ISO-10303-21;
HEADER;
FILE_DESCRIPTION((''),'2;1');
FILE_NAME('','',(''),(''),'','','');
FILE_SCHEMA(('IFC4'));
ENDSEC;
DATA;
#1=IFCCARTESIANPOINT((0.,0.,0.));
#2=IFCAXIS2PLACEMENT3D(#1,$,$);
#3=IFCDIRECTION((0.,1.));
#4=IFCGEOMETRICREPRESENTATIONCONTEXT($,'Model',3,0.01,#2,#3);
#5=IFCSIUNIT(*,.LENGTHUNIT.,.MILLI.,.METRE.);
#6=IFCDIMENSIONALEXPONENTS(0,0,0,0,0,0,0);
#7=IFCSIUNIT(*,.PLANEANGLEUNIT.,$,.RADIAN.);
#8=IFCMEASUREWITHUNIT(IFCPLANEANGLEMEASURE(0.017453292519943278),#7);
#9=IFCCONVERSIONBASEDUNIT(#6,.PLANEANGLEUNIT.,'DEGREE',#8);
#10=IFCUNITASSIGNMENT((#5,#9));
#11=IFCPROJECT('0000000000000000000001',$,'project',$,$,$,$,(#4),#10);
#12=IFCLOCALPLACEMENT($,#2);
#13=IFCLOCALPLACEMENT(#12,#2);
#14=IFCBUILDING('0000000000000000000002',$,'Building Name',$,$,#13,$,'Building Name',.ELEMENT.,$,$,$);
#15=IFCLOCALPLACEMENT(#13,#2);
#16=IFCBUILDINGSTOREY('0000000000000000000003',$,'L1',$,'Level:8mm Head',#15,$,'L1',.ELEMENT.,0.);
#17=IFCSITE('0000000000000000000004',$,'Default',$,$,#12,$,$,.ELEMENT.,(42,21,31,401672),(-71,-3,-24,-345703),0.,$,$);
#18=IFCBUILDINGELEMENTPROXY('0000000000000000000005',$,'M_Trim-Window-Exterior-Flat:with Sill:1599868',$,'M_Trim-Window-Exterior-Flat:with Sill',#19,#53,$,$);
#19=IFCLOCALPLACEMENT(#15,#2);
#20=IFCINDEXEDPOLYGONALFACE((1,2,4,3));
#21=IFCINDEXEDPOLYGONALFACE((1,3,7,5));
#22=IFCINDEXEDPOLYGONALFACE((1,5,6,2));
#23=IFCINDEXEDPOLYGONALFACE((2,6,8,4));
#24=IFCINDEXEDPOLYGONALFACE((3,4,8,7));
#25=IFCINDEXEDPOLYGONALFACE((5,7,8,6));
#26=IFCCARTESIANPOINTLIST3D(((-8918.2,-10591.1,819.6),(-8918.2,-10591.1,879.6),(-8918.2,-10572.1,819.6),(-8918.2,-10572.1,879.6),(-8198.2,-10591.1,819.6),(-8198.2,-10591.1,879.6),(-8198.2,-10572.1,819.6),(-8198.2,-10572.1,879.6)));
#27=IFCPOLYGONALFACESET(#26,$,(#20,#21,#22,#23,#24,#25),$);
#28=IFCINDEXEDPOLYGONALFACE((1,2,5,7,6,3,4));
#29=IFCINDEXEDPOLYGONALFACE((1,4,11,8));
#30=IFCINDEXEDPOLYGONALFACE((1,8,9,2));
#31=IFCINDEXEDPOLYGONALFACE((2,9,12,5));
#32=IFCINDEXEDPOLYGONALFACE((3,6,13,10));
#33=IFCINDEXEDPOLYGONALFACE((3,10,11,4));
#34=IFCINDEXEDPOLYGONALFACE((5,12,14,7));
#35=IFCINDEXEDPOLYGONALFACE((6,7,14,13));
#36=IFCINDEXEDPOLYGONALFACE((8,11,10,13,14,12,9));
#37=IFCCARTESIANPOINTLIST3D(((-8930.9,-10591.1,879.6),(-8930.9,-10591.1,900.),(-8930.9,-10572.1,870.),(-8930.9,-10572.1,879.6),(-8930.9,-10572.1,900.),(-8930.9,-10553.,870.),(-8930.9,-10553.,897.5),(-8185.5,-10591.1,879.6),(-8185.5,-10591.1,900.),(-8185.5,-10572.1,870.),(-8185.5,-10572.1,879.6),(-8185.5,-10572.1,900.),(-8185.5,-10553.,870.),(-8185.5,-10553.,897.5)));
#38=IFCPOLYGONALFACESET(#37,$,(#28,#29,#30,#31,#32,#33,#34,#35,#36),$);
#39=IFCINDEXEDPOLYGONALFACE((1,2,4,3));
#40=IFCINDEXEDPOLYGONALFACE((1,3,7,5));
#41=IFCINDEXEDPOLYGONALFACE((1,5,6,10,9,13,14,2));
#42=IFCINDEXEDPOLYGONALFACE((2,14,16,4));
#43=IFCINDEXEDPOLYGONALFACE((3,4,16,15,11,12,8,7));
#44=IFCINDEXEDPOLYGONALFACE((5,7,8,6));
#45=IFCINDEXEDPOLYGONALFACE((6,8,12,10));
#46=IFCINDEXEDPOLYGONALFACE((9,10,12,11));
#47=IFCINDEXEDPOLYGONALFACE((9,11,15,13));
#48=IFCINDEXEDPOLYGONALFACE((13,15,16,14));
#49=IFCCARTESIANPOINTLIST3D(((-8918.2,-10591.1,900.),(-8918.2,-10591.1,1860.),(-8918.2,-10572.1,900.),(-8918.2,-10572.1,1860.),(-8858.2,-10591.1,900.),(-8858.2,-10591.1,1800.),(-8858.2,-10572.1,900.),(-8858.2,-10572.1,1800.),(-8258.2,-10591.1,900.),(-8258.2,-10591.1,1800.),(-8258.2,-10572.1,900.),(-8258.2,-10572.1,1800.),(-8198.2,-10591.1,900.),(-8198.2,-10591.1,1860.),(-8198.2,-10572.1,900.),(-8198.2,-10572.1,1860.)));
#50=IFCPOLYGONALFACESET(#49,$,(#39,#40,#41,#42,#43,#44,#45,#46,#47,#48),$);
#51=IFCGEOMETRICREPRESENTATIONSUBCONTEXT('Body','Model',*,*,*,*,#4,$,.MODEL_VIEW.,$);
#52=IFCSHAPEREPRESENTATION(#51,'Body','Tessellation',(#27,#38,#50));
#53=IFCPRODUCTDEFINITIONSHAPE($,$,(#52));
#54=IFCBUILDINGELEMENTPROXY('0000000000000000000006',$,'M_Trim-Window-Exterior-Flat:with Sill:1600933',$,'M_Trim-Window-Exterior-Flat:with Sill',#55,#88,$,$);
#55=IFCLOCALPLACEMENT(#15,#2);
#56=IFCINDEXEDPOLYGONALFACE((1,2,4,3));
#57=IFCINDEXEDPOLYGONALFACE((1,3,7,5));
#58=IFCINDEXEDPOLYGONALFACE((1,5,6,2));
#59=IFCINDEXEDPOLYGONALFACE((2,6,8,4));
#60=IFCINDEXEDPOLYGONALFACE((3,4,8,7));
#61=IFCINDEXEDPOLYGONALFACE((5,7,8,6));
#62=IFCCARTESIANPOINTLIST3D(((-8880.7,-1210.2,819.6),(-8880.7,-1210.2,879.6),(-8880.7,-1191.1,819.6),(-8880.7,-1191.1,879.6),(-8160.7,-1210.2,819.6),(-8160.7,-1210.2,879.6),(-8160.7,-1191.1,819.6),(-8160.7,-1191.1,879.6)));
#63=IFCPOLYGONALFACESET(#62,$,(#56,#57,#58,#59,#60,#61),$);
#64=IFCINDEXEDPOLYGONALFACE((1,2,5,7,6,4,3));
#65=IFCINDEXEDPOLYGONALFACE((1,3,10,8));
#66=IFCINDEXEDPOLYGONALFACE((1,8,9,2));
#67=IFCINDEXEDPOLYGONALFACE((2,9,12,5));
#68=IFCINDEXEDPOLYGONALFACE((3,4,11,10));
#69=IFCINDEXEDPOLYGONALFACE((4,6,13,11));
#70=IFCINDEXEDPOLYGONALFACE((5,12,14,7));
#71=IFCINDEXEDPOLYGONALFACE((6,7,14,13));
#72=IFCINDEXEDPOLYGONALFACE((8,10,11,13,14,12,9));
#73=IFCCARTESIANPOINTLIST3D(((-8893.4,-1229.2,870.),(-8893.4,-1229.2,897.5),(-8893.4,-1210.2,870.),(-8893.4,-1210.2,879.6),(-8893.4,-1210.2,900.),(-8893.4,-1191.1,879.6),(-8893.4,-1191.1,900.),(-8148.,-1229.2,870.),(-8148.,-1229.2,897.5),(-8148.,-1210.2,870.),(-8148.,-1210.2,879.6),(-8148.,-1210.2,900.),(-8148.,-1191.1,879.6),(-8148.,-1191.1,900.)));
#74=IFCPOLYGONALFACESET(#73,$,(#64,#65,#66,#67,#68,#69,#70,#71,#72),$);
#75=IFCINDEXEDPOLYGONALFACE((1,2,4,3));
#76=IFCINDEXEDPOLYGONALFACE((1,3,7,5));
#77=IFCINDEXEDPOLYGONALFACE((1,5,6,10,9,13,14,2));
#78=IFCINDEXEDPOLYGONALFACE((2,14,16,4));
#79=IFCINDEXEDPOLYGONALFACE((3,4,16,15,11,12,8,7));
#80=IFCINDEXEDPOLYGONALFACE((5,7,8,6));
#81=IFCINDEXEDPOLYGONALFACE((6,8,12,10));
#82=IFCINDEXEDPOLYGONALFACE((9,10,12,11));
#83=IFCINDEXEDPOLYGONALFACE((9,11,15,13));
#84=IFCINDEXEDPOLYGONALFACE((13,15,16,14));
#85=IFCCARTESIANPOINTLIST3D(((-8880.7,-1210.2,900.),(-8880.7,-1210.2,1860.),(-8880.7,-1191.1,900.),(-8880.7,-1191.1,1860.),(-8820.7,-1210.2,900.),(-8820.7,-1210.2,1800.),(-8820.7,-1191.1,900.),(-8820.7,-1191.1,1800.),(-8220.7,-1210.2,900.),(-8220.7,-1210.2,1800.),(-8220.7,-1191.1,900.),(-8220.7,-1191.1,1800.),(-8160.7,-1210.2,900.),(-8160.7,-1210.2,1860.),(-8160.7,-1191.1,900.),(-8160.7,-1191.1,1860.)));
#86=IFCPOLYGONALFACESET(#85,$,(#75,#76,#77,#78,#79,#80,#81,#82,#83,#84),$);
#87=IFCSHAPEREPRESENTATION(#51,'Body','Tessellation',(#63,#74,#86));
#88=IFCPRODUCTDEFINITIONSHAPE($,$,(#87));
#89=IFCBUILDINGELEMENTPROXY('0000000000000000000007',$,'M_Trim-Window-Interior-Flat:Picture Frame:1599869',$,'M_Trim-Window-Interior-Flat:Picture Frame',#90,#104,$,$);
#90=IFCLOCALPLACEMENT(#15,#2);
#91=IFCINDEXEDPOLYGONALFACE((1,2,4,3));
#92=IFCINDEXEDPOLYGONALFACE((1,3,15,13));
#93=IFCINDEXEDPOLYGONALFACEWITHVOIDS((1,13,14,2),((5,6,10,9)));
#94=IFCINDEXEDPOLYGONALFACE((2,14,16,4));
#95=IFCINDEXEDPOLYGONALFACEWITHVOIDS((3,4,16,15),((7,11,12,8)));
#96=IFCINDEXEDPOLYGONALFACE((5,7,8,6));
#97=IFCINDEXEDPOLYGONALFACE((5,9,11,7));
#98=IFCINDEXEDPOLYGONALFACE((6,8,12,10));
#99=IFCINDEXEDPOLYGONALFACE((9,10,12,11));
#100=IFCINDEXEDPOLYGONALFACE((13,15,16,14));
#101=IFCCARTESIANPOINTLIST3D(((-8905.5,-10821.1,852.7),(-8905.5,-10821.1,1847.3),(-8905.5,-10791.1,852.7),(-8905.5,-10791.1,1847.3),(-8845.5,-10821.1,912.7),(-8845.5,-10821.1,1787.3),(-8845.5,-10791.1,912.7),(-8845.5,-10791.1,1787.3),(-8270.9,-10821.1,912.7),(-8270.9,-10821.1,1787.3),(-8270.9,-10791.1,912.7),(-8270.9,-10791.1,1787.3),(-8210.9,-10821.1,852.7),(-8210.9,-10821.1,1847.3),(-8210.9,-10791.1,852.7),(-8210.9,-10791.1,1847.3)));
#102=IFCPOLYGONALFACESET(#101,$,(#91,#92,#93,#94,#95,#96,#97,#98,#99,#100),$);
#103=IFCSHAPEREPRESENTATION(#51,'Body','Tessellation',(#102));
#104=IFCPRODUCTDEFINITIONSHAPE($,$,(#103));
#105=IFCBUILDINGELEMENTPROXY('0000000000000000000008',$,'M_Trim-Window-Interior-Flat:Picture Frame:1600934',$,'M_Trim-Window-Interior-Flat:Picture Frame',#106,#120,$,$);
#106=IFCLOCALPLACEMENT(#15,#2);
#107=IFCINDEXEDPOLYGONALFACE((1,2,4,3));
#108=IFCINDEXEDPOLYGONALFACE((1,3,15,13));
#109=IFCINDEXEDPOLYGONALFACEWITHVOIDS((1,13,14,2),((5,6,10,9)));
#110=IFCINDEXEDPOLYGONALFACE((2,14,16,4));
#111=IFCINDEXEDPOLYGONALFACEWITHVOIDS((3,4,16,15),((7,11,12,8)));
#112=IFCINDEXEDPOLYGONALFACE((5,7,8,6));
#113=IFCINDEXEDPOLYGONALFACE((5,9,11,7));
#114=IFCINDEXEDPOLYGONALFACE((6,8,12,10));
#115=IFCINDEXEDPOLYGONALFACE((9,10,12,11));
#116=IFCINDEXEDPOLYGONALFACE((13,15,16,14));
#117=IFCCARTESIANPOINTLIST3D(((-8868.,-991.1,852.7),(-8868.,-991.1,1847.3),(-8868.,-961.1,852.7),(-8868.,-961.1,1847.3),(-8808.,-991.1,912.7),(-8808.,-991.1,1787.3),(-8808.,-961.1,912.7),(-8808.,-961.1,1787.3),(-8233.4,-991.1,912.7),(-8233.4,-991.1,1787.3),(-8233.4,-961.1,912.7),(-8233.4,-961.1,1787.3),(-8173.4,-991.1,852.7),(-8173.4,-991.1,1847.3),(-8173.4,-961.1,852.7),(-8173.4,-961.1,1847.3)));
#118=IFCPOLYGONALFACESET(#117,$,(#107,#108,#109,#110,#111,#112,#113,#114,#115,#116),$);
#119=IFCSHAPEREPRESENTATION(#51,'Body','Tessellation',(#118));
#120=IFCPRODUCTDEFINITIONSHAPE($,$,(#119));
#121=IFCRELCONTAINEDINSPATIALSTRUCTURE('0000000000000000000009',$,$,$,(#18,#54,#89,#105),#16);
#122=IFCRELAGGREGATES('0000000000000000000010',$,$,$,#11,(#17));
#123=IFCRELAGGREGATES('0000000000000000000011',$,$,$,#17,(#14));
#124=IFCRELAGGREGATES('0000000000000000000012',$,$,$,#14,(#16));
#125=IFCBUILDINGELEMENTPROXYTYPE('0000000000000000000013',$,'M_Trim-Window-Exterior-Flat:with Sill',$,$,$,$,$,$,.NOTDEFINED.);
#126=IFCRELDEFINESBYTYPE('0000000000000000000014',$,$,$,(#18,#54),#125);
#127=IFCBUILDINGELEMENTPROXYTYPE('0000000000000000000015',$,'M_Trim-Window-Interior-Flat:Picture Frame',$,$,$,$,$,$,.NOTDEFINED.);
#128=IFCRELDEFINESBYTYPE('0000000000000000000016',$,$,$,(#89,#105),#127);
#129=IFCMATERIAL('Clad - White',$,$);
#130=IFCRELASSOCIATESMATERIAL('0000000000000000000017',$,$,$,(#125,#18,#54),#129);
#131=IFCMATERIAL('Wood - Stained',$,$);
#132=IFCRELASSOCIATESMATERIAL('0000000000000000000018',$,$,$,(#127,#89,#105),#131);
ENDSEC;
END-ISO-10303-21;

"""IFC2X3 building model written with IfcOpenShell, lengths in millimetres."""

from ifc_helpers import new_model, entity, si_unit, converted_unit, direction, frame, frame_2d, origin, place, context, subcontext, project, spatial, polyline, rectangle, outline, extrude, source, transform, mapped, material, type_object, type_shapes, element, save


model = new_model("IFC2X3")

# Units and contexts
model_context = context("Model", 3, precision=0.01, world=origin(), true_north=direction((0.0, 1.0)))
body_context = subcontext(model_context, "Body", "Model", "MODEL_VIEW")
ifc_project = project(units=[si_unit("LENGTHUNIT", "METRE", prefix="MILLI"), converted_unit("PLANEANGLEUNIT", "DEGREE", entity("IfcPlaneAngleMeasure", 0.017453292519943278), si_unit("PLANEANGLEUNIT", "RADIAN"), dimensions=[0, 0, 0, 0, 0, 0, 0])], contexts=[model_context])

# Site, building, storey
site_placement = place(None, origin())
site = spatial("IfcSite", under=ifc_project, at=site_placement, Name="Default", CompositionType="ELEMENT", RefLatitude=(42, 21, 31, 401672), RefLongitude=(-71, -3, -24, -345703), RefElevation=0.0)
building_placement = place(site_placement, origin())
building = spatial("IfcBuilding", under=site, at=building_placement, Name="Building Name", LongName="Building Name", CompositionType="ELEMENT")
storey_placement = place(building_placement, origin())
storey = spatial("IfcBuildingStorey", under=building, at=storey_placement, Name="L1", ObjectType="Level:8mm Head", LongName="L1", CompositionType="ELEMENT", Elevation=0.0)

# Building element proxies
ifc_material_1 = material(Name="Clad - White")
ifc_material_2 = material(Name="Wood - Stained")
building_element_proxy_type_1 = type_object("IfcBuildingElementProxyType", Name="M_Trim-Window-Exterior-Flat:with Sill", PredefinedType="NOTDEFINED", material=ifc_material_1)
shared_shape_1 = source(origin(), body_context, "Body", "SweptSolid", [
    extrude(rectangle(XDim=720.0, YDim=60.0, at=frame_2d((0.0, 0.0), x_axis=(1.0, 0.0))), frame((0.0, -950.4, 0.0), z_axis=(0.0, 0.0, 1.0), x_axis=(-1.0, 0.0, 0.0)), (0.0, 0.0, 1.0), 19.0),
    extrude(outline(polyline([(-19.0, -15.2), (0.0, -15.2), (0.0, -5.7), (19.0, -5.7), (19.0, 14.8), (0.0, 14.8), (-19.0, 12.3), (-19.0, -15.2)])), frame((-372.7, -914.8, 19.0), z_axis=(1.0, 0.0, 0.0), x_axis=(0.0, 0.0, -1.0)), (0.0, 0.0, 1.0), 745.4),
    extrude(outline(polyline([(-495.0, -360.0), (465.0, -360.0), (465.0, -300.0), (-435.0, -300.0), (-435.0, 300.0), (465.0, 300.0), (465.0, 360.0), (-495.0, 360.0), (-495.0, -360.0)])), frame((0.0, -435.0, 0.0), z_axis=(0.0, 0.0, 1.0), x_axis=(0.0, -1.0, 0.0)), (0.0, 0.0, 1.0), 19.0),
])
type_shapes(building_element_proxy_type_1, [shared_shape_1])
for number, where, z_axis, x_axis, name in (
    (1, (-8558.2, -10591.1, 1800.0), (0.0, 1.0, 0.0), (-1.0, 0.0, 0.0), "M_Trim-Window-Exterior-Flat:with Sill:1599868"),
    (2, (-8520.7, -1191.1, 1800.0), (0.0, -1.0, 0.0), (1.0, 0.0, 0.0), "M_Trim-Window-Exterior-Flat:with Sill:1600933"),
):
    element("IfcBuildingElementProxy", number, at=place(storey_placement, frame(where, z_axis=z_axis, x_axis=x_axis)), inside=storey, type_object=building_element_proxy_type_1, material=ifc_material_1, Name=name, ObjectType="M_Trim-Window-Exterior-Flat:with Sill", context=body_context, shape_type="MappedRepresentation", body=[
        mapped(shared_shape_1, transform((0.0, 0.0, 0.0), scale=1.0)),
    ])
building_element_proxy_type_2 = type_object("IfcBuildingElementProxyType", Name="M_Trim-Window-Interior-Flat:Picture Frame", PredefinedType="NOTDEFINED", material=ifc_material_2)
shared_shape_2 = source(origin(), body_context, "Body", "SweptSolid", [
    extrude(outline(polyline([(-347.3, -497.3), (347.3, -497.3), (347.3, 497.3), (-347.3, 497.3), (-347.3, -497.3)]), holes=[polyline([(-287.3, -437.3), (-287.3, 437.3), (287.3, 437.3), (287.3, -437.3), (-287.3, -437.3)])]), frame((0.0, -450.0, 0.0), z_axis=(0.0, 0.0, 1.0), x_axis=(-1.0, 0.0, 0.0)), (0.0, 0.0, 1.0), 30.0),
])
type_shapes(building_element_proxy_type_2, [shared_shape_2])
for number, where, z_axis, x_axis, name in (
    (3, (-8558.2, -10791.1, 1800.0), (0.0, -1.0, 0.0), (1.0, 0.0, 0.0), "M_Trim-Window-Interior-Flat:Picture Frame:1599869"),
    (4, (-8520.7, -991.1, 1800.0), (0.0, 1.0, 0.0), (-1.0, 0.0, 0.0), "M_Trim-Window-Interior-Flat:Picture Frame:1600934"),
):
    element("IfcBuildingElementProxy", number, at=place(storey_placement, frame(where, z_axis=z_axis, x_axis=x_axis)), inside=storey, type_object=building_element_proxy_type_2, material=ifc_material_2, Name=name, ObjectType="M_Trim-Window-Interior-Flat:Picture Frame", context=body_context, shape_type="MappedRepresentation", body=[
        mapped(shared_shape_2, transform((0.0, 0.0, 0.0), scale=1.0)),
    ])

save(model, "model.ifc")
